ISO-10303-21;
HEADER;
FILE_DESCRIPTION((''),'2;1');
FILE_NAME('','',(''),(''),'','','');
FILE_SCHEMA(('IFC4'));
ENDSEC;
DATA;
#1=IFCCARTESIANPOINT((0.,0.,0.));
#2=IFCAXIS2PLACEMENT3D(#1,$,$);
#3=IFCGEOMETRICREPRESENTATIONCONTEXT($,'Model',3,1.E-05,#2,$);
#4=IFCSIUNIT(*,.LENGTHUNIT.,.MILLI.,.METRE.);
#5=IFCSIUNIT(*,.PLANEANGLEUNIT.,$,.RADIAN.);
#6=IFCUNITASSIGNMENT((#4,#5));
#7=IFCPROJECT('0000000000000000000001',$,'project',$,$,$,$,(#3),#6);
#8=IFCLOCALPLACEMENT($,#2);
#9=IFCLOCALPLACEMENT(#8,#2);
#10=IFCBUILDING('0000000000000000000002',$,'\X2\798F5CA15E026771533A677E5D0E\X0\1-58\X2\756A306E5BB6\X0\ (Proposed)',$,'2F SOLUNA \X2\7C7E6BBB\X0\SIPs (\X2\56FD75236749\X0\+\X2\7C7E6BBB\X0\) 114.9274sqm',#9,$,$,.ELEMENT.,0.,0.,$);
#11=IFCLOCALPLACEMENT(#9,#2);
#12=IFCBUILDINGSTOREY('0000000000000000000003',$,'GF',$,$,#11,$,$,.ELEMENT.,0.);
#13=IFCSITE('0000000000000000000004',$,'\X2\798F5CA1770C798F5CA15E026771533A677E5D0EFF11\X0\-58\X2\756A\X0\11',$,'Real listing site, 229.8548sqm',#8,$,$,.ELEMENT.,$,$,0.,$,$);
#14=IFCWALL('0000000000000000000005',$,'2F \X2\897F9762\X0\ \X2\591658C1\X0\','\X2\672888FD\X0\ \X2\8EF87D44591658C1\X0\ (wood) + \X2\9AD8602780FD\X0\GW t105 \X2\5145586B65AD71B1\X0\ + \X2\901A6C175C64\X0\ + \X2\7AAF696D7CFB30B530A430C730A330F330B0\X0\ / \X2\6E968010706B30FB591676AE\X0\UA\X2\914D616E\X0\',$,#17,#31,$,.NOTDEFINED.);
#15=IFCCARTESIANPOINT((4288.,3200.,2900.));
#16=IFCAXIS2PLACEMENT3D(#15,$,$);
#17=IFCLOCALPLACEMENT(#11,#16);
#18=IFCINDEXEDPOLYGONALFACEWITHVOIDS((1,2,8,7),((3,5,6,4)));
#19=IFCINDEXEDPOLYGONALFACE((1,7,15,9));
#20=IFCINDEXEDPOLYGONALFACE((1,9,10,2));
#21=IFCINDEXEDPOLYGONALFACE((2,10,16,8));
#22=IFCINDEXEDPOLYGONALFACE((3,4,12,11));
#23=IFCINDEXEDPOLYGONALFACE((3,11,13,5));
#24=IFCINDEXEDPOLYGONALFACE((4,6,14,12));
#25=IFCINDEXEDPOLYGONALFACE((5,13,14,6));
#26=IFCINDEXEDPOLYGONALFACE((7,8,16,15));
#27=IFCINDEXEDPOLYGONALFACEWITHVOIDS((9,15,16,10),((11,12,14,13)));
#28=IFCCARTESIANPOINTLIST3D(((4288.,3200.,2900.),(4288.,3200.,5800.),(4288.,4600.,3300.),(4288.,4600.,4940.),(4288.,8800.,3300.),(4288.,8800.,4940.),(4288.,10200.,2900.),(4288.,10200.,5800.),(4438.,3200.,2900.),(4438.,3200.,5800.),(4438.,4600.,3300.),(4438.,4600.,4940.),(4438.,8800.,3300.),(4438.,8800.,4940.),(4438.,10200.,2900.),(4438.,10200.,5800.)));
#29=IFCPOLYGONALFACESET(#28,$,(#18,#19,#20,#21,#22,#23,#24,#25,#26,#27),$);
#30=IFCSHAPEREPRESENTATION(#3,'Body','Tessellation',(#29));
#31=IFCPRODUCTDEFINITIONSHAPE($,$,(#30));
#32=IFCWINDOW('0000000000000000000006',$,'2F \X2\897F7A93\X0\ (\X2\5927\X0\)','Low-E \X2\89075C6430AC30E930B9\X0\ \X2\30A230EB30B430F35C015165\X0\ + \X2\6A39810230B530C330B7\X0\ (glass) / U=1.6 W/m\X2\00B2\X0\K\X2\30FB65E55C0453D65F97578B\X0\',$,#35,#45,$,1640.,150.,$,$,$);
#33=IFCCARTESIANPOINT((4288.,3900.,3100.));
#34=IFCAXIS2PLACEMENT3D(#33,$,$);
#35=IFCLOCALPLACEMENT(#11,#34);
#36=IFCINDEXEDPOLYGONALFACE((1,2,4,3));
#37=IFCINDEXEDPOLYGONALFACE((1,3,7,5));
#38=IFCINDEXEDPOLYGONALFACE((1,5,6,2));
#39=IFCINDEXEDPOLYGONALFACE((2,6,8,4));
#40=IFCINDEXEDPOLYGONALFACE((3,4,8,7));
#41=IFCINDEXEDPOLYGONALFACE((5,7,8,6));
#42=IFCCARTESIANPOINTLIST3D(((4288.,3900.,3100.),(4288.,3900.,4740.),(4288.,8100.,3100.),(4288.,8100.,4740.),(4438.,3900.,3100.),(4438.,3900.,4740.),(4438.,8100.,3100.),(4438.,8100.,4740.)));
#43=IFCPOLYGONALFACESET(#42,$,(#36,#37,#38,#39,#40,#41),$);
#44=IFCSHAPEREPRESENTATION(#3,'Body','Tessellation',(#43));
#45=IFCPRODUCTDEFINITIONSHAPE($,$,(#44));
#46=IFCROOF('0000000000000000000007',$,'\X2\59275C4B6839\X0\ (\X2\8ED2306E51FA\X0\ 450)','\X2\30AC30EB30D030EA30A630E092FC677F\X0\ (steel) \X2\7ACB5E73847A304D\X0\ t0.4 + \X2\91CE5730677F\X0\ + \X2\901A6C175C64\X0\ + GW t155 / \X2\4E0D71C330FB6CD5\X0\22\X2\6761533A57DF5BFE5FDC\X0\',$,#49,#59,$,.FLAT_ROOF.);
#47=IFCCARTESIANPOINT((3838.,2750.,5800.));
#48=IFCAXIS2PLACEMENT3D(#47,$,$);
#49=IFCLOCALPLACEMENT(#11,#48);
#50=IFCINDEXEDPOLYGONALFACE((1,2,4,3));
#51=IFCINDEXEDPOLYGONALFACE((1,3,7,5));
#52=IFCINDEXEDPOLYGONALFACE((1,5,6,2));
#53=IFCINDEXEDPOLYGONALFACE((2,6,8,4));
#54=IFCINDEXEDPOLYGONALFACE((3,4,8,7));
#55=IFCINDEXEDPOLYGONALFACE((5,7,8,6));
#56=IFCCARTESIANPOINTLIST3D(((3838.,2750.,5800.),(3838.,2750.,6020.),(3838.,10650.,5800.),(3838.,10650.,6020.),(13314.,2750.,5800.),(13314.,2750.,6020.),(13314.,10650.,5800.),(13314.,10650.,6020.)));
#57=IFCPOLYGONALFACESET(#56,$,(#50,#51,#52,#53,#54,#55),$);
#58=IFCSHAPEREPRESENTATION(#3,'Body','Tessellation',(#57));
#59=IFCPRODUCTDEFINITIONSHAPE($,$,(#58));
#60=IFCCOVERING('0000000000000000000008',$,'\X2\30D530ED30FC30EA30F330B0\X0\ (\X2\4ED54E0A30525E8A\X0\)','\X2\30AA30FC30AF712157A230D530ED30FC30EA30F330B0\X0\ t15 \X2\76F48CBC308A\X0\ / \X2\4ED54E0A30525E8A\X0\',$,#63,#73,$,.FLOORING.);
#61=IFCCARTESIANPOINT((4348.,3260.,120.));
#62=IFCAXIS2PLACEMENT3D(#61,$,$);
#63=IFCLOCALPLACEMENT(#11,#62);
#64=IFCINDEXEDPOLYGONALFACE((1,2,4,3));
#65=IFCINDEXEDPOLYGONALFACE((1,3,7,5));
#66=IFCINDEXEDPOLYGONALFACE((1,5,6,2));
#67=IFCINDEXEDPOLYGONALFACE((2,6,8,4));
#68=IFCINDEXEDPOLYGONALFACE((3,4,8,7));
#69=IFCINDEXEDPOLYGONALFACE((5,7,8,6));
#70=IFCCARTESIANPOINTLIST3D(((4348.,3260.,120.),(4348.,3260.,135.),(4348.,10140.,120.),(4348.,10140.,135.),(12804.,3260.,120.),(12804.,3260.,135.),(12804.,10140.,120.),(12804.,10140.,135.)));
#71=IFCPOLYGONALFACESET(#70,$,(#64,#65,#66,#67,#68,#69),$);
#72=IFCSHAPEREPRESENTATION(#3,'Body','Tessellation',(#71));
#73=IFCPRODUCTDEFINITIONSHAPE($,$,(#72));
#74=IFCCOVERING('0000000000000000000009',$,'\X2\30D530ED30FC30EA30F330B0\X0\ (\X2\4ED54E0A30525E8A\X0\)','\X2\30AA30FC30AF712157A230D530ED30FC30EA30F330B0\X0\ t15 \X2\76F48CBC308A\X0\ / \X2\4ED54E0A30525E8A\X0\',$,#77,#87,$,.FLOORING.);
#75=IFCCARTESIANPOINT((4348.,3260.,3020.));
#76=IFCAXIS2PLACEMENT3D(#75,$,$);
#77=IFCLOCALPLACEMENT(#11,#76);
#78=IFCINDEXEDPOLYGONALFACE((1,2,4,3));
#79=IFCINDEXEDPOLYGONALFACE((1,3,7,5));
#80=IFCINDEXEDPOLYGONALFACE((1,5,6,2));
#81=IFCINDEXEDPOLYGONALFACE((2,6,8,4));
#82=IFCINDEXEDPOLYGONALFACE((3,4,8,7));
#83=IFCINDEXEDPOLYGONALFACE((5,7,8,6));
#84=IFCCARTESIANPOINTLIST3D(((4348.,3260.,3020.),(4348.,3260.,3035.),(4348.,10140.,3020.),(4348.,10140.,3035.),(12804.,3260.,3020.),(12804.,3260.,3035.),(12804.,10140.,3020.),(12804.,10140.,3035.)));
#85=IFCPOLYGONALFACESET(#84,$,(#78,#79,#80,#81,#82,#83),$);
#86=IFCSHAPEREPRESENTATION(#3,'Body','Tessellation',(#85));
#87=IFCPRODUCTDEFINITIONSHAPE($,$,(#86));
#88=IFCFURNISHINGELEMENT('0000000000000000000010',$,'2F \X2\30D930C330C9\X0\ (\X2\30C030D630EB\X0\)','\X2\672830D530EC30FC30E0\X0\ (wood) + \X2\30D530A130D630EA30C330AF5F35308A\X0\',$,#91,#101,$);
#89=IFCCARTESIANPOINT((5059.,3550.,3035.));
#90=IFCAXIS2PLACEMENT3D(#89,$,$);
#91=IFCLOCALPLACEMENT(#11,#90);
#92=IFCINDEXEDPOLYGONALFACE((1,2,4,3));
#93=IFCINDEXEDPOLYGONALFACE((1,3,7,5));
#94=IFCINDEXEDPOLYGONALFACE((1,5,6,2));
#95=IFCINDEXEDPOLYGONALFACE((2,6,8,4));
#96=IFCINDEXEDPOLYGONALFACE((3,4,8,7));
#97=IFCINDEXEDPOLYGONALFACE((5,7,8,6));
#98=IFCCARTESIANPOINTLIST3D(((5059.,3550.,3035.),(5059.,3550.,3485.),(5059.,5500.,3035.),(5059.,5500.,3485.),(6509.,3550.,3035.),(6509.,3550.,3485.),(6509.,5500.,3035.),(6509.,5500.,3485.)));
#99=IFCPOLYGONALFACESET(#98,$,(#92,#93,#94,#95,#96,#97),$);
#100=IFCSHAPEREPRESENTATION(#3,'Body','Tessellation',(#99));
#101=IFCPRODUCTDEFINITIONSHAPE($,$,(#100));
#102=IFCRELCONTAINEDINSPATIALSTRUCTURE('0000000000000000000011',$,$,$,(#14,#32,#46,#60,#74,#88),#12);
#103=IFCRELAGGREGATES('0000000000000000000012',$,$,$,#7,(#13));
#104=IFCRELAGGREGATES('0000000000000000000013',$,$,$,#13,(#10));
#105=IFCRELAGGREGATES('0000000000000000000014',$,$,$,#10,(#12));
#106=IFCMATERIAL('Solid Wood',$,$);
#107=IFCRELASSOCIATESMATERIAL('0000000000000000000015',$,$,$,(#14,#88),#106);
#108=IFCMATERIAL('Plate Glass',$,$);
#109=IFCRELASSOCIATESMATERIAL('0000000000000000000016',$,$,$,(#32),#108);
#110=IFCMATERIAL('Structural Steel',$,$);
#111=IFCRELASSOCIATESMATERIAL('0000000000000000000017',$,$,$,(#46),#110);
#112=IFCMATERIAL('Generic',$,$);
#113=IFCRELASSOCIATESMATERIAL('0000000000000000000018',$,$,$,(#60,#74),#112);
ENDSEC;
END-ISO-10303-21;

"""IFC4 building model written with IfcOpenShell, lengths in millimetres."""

from ifc_helpers import new_model, si_unit, frame, frame_2d, origin, place, context, project, spatial, rectangle, extrude, material, element, fill, save


model = new_model("IFC4")

# Units and contexts
model_context = context("Model", 3, precision=1e-05, world=origin())
ifc_project = project(units=[si_unit("LENGTHUNIT", "METRE", prefix="MILLI"), si_unit("PLANEANGLEUNIT", "RADIAN")], contexts=[model_context])

# Site, building, storey
site_placement = place(None, origin())
site = spatial("IfcSite", under=ifc_project, at=site_placement, Name="福岡県福岡市東区松崎１-58番11", ObjectType="Real listing site, 229.8548sqm", CompositionType="ELEMENT", RefElevation=0.0)
building_placement = place(site_placement, origin())
building = spatial("IfcBuilding", under=site, at=building_placement, Name="福岡市東区松崎1-58番の家 (Proposed)", ObjectType="2F SOLUNA 籾殻SIPs (国産杉+籾殻) 114.9274sqm", CompositionType="ELEMENT", ElevationOfRefHeight=0.0, ElevationOfTerrain=0.0)
storey_placement = place(building_placement, origin())
storey = spatial("IfcBuildingStorey", under=building, at=storey_placement, Name="GF", CompositionType="ELEMENT", Elevation=0.0)

# Shared definitions
ifc_material_1 = material(Name="Solid Wood")

# Shared definitions
ifc_material_2 = material(Name="Plate Glass")

# Wall, opening, window
wall_1_placement = place(storey_placement, frame((4288.0, 3200.0, 2900.0)))
wall_1 = element("IfcWall", 1, at=wall_1_placement, inside=storey, material=ifc_material_1, Name="2F 西面 外壁", Description="木製 軸組外壁 (wood) + 高性能GW t105 充填断熱 + 通気層 + 窯業系サイディング / 準耐火・外皮UA配慮", PredefinedType="NOTDEFINED", context=model_context, shape_type="SweptSolid", body=[
    extrude(rectangle(XDim=150.0, YDim=7000.0, at=frame_2d((75.0, 3500.0))), frame((4288.0, 3200.0, 2900.0)), (0.0, 0.0, 1.0), 2900.0),
])
opening_1_placement = place(storey_placement, frame((4288.0, 3900.0, 3100.0)))
opening_1 = element("IfcOpeningElement", 2, at=opening_1_placement, cuts=wall_1, PredefinedType="NOTDEFINED", context=model_context, shape_type="SweptSolid", body=[
    extrude(rectangle(XDim=150.0, YDim=4200.0, at=frame_2d((75.0, 2100.0))), frame((4288.0, 3900.0, 3100.0)), (0.0, 0.0, 1.0), 1640.0),
])
window_1_placement = place(storey_placement, frame((4288.0, 3900.0, 3100.0)))
window_1 = element("IfcWindow", 3, at=window_1_placement, inside=storey, material=ifc_material_2, Name="2F 西窓 (大)", Description="Low-E 複層ガラス アルゴン封入 + 樹脂サッシ (glass) / U=1.6 W/m²K・日射取得型", OverallHeight=1640.0, OverallWidth=150.0, context=model_context, shape_type="SweptSolid", body=[
    extrude(rectangle(XDim=150.0, YDim=4200.0, at=frame_2d((75.0, 2100.0))), frame((4288.0, 3900.0, 3100.0)), (0.0, 0.0, 1.0), 1640.0),
])
fill(opening_1, window_1)

# Roof
ifc_material_3 = material(Name="Structural Steel")
roof_placement = place(storey_placement, frame((3838.0, 2750.0, 5800.0)))
element("IfcRoof", 4, at=roof_placement, inside=storey, material=ifc_material_3, Name="大屋根 (軒の出 450)", Description="ガルバリウム鋼板 (steel) 立平葺き t0.4 + 野地板 + 通気層 + GW t155 / 不燃・法22条区域対応", PredefinedType="FLAT_ROOF", context=model_context, shape_type="SweptSolid", body=[
    extrude(rectangle(XDim=9476.0, YDim=7900.0, at=frame_2d((4738.0, 3950.0))), frame((3838.0, 2750.0, 5800.0)), (0.0, 0.0, 1.0), 220.0),
])

# Coverings
ifc_material_4 = material(Name="Generic")
covering_1_placement = place(storey_placement, frame((4348.0, 3260.0, 120.0)))
element("IfcCovering", 5, at=covering_1_placement, inside=storey, material=ifc_material_4, Name="フローリング (仕上げ床)", Description="オーク無垢フローリング t15 直貼り / 仕上げ床", PredefinedType="FLOORING", context=model_context, shape_type="SweptSolid", body=[
    extrude(rectangle(XDim=8456.0, YDim=6880.0, at=frame_2d((4228.0, 3440.0))), frame((4348.0, 3260.0, 120.0)), (0.0, 0.0, 1.0), 15.0),
])
covering_2_placement = place(storey_placement, frame((4348.0, 3260.0, 3020.0)))
element("IfcCovering", 6, at=covering_2_placement, inside=storey, material=ifc_material_4, Name="フローリング (仕上げ床)", Description="オーク無垢フローリング t15 直貼り / 仕上げ床", PredefinedType="FLOORING", context=model_context, shape_type="SweptSolid", body=[
    extrude(rectangle(XDim=8456.0, YDim=6880.0, at=frame_2d((4228.0, 3440.0))), frame((4348.0, 3260.0, 3020.0)), (0.0, 0.0, 1.0), 15.0),
])

# Furnishing element
furnishing_placement = place(storey_placement, frame((5059.0, 3550.0, 3035.0)))
element("IfcFurnishingElement", 7, at=furnishing_placement, inside=storey, material=ifc_material_1, Name="2F ベッド (ダブル)", Description="木フレーム (wood) + ファブリック張り", context=model_context, shape_type="SweptSolid", body=[
    extrude(rectangle(XDim=1450.0, YDim=1950.0, at=frame_2d((725.0, 975.0))), frame((5059.0, 3550.0, 3035.0)), (0.0, 0.0, 1.0), 450.0),
])

save(model, "model.ifc")
